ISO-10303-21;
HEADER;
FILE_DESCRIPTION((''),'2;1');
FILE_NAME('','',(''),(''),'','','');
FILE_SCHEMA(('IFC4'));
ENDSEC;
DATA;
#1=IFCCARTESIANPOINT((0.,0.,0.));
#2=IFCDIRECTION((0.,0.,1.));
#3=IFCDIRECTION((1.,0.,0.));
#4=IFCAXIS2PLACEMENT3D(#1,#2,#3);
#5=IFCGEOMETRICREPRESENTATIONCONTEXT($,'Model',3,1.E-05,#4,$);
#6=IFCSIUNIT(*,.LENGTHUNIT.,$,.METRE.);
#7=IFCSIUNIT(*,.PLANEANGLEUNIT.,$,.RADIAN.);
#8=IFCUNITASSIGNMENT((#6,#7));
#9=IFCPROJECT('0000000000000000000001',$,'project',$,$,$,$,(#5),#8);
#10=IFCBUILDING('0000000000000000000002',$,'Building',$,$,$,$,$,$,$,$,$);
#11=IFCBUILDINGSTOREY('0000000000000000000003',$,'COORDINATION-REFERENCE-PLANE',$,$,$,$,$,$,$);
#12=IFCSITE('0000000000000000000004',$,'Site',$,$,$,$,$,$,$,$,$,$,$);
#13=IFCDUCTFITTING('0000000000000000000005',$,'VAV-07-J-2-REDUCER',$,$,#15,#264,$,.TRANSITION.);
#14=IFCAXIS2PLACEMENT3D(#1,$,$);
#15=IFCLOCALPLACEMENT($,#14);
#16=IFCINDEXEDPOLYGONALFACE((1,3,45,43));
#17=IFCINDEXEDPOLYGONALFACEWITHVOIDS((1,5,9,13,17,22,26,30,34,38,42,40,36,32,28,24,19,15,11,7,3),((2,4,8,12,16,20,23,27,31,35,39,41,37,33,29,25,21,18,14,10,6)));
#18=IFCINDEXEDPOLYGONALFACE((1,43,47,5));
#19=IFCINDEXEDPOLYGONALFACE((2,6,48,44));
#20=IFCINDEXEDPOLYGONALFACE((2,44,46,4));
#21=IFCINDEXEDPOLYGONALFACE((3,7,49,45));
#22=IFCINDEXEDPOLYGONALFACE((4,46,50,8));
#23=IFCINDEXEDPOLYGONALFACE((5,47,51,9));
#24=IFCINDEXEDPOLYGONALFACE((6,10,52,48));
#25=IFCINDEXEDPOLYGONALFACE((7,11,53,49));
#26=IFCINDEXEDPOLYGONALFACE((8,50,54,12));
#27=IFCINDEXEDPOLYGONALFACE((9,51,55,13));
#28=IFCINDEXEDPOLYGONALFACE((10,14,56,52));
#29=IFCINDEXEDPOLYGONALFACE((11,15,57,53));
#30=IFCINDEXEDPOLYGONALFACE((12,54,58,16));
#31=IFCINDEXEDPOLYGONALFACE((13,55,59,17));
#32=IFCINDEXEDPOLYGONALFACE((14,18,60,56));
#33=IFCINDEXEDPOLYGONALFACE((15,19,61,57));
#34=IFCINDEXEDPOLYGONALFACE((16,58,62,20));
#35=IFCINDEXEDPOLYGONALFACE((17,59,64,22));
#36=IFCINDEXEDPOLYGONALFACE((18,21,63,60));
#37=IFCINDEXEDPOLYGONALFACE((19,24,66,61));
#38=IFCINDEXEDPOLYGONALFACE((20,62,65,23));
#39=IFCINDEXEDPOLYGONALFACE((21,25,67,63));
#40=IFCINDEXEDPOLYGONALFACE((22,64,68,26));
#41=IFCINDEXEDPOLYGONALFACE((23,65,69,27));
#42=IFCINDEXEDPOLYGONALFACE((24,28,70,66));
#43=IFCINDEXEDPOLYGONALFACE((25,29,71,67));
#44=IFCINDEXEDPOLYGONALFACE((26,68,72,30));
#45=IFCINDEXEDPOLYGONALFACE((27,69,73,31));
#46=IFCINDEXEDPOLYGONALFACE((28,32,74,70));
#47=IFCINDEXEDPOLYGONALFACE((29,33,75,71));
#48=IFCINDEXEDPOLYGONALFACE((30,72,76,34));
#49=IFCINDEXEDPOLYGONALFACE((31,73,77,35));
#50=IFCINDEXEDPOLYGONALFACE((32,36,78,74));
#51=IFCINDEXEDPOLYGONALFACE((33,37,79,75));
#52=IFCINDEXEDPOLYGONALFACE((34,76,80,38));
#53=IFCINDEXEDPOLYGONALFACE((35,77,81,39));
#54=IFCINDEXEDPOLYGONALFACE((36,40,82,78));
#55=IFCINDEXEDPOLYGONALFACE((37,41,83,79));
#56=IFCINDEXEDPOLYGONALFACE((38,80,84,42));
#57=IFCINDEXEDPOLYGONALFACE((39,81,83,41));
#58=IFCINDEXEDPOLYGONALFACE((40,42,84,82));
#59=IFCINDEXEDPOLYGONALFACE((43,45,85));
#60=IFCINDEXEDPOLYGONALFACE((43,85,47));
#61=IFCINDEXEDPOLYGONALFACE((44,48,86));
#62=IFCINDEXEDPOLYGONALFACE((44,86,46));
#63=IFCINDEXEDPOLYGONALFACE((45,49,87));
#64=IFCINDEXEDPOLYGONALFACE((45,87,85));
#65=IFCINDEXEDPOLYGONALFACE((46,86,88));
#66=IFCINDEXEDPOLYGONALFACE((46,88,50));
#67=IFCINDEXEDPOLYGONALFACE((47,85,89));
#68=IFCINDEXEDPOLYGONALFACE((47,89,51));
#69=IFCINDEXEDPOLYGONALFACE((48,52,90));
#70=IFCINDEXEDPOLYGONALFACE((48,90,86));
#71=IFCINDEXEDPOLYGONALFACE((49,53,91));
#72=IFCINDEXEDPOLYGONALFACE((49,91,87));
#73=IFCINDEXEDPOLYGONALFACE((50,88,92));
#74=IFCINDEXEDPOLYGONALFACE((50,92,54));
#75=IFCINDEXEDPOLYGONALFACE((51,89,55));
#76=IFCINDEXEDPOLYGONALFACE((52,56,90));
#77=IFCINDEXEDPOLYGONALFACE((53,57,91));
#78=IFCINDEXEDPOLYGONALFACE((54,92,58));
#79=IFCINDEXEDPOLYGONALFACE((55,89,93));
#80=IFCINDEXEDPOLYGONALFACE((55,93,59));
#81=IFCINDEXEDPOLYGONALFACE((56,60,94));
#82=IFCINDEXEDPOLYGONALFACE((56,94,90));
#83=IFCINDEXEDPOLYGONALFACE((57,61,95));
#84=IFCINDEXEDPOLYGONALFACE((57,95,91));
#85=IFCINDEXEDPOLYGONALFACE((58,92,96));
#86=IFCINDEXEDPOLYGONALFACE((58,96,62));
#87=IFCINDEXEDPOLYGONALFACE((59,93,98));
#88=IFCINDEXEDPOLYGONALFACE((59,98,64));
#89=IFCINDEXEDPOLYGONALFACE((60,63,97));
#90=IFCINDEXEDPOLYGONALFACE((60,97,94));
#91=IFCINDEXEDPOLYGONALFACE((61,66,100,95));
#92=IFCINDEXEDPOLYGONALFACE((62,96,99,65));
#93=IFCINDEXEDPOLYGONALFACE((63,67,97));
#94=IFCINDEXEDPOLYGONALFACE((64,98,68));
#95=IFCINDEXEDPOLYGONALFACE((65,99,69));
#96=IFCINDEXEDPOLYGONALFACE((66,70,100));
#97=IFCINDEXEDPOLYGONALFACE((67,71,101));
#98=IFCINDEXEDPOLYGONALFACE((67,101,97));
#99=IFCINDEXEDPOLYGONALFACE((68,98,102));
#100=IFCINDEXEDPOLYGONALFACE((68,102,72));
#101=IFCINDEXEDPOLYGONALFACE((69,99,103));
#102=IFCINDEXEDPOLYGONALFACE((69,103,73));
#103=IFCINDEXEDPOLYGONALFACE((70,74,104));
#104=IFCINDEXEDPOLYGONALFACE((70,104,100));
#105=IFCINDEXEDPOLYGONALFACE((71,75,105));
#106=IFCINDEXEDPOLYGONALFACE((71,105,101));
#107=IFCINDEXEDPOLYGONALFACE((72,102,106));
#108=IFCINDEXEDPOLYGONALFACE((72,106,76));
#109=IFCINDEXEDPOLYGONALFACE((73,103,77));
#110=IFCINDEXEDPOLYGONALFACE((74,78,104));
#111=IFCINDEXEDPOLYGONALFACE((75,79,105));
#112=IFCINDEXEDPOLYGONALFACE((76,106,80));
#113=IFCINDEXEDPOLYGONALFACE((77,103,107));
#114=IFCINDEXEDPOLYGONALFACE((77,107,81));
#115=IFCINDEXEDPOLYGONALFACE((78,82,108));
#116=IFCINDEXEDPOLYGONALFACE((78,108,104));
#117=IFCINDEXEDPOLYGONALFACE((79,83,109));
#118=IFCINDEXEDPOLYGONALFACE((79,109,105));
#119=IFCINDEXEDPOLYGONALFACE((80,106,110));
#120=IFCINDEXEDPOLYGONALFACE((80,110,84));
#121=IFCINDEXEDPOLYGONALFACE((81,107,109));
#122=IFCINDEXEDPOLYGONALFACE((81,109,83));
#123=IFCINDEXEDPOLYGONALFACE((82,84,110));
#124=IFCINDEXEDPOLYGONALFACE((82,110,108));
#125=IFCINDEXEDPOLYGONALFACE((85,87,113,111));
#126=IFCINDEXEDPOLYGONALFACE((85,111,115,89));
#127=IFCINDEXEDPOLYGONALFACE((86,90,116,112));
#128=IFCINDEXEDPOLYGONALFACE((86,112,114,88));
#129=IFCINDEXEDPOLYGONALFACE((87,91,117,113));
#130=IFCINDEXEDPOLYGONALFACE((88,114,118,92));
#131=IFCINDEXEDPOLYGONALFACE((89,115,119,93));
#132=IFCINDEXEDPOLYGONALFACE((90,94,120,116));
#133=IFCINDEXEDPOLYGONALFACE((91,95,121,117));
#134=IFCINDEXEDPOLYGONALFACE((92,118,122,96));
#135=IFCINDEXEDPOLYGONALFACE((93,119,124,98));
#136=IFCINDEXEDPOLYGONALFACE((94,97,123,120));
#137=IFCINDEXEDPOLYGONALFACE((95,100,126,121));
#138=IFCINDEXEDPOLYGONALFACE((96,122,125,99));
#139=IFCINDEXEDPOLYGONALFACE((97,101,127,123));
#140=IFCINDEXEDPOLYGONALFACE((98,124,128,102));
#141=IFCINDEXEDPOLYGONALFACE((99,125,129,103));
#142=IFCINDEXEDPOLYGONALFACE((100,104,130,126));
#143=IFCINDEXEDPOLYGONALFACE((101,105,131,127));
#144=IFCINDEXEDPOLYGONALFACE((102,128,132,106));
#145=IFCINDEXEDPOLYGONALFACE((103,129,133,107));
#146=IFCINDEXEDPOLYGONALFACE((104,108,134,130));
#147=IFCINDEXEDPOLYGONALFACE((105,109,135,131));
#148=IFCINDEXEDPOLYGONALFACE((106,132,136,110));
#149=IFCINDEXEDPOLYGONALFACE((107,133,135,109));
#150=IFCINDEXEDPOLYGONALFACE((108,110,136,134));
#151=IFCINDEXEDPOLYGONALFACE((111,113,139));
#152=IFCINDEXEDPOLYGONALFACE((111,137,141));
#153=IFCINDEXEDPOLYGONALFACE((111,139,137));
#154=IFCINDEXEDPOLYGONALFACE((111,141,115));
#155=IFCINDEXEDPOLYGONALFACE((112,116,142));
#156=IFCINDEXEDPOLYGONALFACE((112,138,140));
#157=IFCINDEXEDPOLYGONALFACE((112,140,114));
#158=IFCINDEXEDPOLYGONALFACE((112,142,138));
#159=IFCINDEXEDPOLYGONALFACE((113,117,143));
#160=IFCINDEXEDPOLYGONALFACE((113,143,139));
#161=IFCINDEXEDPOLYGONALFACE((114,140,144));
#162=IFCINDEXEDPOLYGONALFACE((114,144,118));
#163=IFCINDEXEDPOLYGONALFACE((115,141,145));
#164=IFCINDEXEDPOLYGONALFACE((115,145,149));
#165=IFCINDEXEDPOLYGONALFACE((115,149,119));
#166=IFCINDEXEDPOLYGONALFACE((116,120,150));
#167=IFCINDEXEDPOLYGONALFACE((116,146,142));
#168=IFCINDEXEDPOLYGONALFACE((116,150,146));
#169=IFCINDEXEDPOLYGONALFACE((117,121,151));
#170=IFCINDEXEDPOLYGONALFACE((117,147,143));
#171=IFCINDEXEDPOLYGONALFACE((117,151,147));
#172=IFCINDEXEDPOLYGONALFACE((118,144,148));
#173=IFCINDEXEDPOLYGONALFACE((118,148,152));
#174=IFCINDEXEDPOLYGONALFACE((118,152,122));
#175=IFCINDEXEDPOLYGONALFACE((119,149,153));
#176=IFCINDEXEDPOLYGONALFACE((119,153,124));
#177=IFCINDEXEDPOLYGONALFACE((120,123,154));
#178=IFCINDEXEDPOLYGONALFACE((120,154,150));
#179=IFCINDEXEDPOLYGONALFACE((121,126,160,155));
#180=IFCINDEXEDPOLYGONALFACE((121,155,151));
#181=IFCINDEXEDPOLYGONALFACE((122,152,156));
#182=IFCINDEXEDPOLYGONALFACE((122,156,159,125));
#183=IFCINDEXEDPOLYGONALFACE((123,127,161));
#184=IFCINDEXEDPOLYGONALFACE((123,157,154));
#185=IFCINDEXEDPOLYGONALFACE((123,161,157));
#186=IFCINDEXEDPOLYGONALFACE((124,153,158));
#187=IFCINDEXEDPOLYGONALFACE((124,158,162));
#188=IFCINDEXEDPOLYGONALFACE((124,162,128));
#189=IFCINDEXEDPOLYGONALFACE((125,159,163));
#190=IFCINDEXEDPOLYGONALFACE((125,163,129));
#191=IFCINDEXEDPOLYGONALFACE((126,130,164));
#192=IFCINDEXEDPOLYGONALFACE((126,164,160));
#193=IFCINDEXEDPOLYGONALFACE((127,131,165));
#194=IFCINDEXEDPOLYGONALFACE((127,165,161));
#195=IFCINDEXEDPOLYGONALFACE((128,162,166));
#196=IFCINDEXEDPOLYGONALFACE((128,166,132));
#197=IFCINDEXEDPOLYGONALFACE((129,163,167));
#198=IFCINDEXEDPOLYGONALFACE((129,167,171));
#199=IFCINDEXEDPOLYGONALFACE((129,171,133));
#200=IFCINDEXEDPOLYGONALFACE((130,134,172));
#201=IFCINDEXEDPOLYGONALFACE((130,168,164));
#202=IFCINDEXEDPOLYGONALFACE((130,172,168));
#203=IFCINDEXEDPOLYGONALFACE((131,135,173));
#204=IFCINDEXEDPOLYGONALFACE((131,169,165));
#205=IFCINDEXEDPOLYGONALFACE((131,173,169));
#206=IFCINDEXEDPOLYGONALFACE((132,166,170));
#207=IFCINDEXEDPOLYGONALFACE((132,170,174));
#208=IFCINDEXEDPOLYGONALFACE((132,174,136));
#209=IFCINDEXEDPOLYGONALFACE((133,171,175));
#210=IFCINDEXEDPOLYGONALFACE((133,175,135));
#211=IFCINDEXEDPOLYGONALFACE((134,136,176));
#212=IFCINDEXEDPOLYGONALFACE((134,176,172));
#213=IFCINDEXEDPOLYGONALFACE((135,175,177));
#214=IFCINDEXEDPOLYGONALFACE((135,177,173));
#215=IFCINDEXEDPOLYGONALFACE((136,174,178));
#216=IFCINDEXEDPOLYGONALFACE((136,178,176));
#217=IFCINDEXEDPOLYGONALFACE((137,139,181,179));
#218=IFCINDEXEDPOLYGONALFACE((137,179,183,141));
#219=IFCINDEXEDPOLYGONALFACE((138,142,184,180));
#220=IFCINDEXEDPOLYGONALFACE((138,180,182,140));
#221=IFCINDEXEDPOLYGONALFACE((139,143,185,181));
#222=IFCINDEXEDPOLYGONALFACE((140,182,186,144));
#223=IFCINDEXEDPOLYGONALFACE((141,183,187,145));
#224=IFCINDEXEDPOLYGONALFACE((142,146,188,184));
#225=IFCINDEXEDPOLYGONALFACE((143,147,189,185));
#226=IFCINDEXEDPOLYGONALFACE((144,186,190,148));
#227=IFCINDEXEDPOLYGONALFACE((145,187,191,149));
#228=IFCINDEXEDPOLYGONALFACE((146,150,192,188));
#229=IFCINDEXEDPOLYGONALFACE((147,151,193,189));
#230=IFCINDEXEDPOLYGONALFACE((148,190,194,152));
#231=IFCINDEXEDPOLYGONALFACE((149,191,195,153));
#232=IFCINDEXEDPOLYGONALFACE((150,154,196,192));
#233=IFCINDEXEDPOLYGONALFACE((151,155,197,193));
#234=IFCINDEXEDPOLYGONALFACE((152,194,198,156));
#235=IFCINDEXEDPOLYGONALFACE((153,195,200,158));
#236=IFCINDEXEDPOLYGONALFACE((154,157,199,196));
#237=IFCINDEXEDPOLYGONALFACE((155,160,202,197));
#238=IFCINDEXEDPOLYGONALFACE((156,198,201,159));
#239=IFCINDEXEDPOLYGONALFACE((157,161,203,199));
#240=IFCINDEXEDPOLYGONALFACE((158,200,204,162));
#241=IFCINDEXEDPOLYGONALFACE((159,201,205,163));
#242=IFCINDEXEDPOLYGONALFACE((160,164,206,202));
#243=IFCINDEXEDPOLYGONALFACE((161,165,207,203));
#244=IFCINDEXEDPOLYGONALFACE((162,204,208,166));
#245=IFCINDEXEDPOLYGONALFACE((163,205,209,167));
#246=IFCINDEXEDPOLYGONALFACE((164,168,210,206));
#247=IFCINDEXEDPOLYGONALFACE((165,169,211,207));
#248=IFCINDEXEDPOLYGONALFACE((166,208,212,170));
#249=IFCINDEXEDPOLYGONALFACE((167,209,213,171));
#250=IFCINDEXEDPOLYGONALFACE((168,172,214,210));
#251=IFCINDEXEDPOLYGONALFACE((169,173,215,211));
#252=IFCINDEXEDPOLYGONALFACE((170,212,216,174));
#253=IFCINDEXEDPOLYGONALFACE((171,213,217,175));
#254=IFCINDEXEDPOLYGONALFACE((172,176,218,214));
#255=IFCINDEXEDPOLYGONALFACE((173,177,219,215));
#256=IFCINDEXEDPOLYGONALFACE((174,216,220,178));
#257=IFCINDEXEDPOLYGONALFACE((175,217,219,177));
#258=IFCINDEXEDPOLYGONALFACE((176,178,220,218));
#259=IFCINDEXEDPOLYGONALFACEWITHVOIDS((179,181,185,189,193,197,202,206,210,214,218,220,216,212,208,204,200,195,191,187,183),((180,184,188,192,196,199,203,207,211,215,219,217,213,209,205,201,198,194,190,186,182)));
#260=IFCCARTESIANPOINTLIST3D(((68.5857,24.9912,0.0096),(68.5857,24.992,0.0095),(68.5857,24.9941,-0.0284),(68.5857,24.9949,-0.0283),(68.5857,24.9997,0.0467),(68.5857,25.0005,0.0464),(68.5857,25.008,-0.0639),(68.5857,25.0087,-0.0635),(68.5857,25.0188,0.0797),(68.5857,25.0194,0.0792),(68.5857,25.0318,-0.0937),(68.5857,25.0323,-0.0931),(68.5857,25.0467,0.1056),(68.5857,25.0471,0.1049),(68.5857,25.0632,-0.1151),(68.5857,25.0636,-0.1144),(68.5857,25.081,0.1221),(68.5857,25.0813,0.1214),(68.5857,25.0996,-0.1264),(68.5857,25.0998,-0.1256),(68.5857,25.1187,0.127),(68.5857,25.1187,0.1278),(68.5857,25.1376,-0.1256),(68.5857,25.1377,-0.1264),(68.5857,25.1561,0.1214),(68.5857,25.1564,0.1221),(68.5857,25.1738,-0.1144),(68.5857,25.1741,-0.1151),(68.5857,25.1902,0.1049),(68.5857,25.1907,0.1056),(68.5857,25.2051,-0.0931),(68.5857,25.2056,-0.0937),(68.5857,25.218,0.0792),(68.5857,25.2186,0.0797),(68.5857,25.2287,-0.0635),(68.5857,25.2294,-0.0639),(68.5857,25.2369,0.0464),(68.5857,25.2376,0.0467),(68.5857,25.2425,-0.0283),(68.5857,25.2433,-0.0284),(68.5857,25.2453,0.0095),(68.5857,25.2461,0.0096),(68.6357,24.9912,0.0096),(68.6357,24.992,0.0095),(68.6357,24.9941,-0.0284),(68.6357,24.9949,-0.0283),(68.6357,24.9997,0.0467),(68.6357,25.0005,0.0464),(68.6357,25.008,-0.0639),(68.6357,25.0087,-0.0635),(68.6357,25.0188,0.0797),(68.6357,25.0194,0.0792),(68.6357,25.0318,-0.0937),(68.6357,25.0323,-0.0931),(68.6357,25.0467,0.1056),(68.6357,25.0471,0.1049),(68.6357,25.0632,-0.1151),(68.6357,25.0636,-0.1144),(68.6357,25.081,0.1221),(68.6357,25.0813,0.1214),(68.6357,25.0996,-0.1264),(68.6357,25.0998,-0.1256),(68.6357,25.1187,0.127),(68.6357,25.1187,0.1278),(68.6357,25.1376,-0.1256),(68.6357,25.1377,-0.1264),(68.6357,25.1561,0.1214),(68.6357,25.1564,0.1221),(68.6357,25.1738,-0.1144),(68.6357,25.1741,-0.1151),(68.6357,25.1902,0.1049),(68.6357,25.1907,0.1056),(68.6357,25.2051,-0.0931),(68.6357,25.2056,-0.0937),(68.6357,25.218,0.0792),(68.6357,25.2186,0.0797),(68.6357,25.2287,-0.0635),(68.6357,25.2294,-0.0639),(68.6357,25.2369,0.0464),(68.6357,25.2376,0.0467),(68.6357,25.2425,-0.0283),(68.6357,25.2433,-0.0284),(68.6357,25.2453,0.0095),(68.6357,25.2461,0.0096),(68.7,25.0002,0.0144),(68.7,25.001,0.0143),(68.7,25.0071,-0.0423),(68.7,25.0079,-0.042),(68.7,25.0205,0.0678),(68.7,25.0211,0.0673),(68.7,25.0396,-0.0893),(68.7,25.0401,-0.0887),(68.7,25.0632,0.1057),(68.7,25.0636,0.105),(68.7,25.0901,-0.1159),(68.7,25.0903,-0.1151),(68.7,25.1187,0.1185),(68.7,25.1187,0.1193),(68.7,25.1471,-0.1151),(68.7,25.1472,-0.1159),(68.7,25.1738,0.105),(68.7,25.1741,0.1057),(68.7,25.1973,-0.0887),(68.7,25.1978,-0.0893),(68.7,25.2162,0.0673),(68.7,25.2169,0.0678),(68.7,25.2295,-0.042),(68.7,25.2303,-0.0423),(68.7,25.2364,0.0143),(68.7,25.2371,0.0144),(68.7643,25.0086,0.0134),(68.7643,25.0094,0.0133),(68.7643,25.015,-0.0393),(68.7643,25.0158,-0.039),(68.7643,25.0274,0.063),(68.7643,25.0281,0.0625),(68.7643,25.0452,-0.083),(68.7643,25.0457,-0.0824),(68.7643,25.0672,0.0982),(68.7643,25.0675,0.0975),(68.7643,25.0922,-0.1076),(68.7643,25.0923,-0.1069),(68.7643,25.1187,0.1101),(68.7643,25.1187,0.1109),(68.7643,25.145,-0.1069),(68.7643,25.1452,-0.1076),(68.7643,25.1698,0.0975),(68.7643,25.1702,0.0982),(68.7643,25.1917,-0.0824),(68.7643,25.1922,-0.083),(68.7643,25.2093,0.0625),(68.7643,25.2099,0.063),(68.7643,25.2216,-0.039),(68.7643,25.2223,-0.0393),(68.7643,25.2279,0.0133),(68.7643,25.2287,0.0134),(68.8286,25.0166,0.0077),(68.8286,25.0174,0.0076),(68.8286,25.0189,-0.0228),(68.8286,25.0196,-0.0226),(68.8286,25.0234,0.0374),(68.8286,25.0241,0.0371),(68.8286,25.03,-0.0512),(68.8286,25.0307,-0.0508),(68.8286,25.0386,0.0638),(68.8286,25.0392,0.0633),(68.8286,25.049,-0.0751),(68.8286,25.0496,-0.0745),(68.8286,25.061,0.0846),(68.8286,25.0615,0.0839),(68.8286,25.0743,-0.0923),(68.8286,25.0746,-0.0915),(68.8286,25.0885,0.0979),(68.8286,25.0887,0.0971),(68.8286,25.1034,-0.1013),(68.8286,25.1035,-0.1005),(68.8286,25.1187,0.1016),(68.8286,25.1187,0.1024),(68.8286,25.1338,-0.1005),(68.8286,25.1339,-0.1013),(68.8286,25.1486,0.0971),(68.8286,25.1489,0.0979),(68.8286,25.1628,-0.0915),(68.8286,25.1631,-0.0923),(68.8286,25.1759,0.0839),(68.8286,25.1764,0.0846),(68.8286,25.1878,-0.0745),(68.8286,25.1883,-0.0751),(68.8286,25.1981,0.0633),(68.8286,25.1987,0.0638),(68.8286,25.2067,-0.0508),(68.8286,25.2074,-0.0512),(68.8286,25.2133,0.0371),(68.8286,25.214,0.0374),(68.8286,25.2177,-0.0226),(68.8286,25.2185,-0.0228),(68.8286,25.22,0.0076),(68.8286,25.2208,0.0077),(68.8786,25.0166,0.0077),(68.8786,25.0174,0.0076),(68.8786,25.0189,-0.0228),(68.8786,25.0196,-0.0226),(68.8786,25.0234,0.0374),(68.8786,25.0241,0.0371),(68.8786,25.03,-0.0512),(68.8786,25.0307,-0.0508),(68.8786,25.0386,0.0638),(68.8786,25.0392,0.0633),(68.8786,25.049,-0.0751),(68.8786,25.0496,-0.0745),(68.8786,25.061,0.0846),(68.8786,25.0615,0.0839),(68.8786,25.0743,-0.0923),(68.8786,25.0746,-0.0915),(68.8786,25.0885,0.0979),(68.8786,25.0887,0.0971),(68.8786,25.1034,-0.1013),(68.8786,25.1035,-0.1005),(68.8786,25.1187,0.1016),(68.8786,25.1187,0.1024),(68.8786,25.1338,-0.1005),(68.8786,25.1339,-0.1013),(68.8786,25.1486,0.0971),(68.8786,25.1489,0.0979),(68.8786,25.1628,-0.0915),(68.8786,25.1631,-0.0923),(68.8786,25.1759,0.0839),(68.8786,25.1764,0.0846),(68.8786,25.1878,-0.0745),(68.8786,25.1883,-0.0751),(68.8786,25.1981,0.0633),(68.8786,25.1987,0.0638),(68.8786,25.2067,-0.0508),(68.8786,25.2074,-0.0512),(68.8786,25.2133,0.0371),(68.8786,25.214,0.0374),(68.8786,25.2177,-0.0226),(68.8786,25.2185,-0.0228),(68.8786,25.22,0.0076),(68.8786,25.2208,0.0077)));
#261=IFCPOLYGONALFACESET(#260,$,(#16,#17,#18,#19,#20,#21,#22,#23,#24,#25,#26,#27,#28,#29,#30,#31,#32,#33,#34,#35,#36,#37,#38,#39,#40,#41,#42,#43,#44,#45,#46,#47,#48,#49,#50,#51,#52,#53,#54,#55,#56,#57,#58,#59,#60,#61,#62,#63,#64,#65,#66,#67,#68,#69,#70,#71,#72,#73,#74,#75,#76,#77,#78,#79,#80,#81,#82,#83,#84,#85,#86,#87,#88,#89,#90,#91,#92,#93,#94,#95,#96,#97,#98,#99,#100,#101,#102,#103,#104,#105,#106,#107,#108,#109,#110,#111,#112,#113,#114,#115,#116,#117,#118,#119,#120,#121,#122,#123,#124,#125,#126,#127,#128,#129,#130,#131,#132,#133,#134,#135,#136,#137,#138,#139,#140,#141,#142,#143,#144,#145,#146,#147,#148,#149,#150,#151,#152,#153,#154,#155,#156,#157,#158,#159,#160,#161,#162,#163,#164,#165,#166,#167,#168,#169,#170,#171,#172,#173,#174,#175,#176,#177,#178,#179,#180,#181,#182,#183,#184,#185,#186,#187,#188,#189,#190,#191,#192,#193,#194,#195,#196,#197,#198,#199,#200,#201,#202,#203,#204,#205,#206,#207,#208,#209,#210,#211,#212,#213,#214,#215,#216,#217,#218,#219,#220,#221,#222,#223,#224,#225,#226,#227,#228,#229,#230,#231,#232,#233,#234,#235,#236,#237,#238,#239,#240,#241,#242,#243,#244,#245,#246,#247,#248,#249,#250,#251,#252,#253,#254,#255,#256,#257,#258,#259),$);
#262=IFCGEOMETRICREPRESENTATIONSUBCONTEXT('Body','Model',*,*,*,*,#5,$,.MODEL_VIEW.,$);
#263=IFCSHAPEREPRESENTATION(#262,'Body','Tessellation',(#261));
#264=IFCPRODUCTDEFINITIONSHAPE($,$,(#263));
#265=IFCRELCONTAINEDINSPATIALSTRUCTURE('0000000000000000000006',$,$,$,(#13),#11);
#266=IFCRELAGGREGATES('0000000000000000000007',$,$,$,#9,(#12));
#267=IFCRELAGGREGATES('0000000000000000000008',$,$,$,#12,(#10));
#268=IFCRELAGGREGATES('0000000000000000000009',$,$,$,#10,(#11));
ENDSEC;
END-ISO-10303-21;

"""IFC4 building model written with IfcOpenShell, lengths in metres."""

from ifc_helpers import new_model, entity, si_unit, frame, origin_with_axes, place, context, subcontext, project, spatial, element, save


model = new_model("IFC4")

# Units and contexts
model_context = context("Model", 3, precision=1e-05, world=origin_with_axes())
body_context_1 = subcontext(model_context, "Body", "Model", "MODEL_VIEW")
ifc_project = project(units=[si_unit("LENGTHUNIT", "METRE"), si_unit("PLANEANGLEUNIT", "RADIAN")], contexts=[model_context])

# Site, building, storey
site = spatial("IfcSite", under=ifc_project, Name="Site")
building = spatial("IfcBuilding", under=site, Name="Building")
storey = spatial("IfcBuildingStorey", under=building, Name="COORDINATION-REFERENCE-PLANE")

# Duct fitting
for number, where, z_axis, x_axis, name in (
    (1, (68.5857, 25.1187, 0.0), (0.0, 1.0, 0.0), (0.0, 0.0, 1.0), "VAV-07-J-2-REDUCER"),
):
    element("IfcDuctFitting", number, at=place(None, frame(where, z_axis=z_axis, x_axis=x_axis)), inside=storey, Name=name, PredefinedType="TRANSITION", context=body_context_1, shape_type="SweptSolid", body=[
        entity("IfcRevolvedAreaSolid", entity("IfcArbitraryClosedProfileDef", "AREA", None, entity("IfcPolyline", [entity("IfcCartesianPoint", [0.1278, 0.0]), entity("IfcCartesianPoint", [0.1278, 0.05]), entity("IfcCartesianPoint", [0.1024, 0.2429]), entity("IfcCartesianPoint", [0.1024, 0.2929]), entity("IfcCartesianPoint", [0.1016, 0.2929]), entity("IfcCartesianPoint", [0.1016, 0.2429]), entity("IfcCartesianPoint", [0.127, 0.05]), entity("IfcCartesianPoint", [0.127, 0.0]), entity("IfcCartesianPoint", [0.1278, 0.0])])), entity("IfcAxis2Placement3D", entity("IfcCartesianPoint", [0.0, 0.0, 0.0])), entity("IfcAxis1Placement", entity("IfcCartesianPoint", [0.0, 0.0, 0.0]), entity("IfcDirection", [0.0, 1.0, 0.0])), 6.283185),
    ])

save(model, "model.ifc")
